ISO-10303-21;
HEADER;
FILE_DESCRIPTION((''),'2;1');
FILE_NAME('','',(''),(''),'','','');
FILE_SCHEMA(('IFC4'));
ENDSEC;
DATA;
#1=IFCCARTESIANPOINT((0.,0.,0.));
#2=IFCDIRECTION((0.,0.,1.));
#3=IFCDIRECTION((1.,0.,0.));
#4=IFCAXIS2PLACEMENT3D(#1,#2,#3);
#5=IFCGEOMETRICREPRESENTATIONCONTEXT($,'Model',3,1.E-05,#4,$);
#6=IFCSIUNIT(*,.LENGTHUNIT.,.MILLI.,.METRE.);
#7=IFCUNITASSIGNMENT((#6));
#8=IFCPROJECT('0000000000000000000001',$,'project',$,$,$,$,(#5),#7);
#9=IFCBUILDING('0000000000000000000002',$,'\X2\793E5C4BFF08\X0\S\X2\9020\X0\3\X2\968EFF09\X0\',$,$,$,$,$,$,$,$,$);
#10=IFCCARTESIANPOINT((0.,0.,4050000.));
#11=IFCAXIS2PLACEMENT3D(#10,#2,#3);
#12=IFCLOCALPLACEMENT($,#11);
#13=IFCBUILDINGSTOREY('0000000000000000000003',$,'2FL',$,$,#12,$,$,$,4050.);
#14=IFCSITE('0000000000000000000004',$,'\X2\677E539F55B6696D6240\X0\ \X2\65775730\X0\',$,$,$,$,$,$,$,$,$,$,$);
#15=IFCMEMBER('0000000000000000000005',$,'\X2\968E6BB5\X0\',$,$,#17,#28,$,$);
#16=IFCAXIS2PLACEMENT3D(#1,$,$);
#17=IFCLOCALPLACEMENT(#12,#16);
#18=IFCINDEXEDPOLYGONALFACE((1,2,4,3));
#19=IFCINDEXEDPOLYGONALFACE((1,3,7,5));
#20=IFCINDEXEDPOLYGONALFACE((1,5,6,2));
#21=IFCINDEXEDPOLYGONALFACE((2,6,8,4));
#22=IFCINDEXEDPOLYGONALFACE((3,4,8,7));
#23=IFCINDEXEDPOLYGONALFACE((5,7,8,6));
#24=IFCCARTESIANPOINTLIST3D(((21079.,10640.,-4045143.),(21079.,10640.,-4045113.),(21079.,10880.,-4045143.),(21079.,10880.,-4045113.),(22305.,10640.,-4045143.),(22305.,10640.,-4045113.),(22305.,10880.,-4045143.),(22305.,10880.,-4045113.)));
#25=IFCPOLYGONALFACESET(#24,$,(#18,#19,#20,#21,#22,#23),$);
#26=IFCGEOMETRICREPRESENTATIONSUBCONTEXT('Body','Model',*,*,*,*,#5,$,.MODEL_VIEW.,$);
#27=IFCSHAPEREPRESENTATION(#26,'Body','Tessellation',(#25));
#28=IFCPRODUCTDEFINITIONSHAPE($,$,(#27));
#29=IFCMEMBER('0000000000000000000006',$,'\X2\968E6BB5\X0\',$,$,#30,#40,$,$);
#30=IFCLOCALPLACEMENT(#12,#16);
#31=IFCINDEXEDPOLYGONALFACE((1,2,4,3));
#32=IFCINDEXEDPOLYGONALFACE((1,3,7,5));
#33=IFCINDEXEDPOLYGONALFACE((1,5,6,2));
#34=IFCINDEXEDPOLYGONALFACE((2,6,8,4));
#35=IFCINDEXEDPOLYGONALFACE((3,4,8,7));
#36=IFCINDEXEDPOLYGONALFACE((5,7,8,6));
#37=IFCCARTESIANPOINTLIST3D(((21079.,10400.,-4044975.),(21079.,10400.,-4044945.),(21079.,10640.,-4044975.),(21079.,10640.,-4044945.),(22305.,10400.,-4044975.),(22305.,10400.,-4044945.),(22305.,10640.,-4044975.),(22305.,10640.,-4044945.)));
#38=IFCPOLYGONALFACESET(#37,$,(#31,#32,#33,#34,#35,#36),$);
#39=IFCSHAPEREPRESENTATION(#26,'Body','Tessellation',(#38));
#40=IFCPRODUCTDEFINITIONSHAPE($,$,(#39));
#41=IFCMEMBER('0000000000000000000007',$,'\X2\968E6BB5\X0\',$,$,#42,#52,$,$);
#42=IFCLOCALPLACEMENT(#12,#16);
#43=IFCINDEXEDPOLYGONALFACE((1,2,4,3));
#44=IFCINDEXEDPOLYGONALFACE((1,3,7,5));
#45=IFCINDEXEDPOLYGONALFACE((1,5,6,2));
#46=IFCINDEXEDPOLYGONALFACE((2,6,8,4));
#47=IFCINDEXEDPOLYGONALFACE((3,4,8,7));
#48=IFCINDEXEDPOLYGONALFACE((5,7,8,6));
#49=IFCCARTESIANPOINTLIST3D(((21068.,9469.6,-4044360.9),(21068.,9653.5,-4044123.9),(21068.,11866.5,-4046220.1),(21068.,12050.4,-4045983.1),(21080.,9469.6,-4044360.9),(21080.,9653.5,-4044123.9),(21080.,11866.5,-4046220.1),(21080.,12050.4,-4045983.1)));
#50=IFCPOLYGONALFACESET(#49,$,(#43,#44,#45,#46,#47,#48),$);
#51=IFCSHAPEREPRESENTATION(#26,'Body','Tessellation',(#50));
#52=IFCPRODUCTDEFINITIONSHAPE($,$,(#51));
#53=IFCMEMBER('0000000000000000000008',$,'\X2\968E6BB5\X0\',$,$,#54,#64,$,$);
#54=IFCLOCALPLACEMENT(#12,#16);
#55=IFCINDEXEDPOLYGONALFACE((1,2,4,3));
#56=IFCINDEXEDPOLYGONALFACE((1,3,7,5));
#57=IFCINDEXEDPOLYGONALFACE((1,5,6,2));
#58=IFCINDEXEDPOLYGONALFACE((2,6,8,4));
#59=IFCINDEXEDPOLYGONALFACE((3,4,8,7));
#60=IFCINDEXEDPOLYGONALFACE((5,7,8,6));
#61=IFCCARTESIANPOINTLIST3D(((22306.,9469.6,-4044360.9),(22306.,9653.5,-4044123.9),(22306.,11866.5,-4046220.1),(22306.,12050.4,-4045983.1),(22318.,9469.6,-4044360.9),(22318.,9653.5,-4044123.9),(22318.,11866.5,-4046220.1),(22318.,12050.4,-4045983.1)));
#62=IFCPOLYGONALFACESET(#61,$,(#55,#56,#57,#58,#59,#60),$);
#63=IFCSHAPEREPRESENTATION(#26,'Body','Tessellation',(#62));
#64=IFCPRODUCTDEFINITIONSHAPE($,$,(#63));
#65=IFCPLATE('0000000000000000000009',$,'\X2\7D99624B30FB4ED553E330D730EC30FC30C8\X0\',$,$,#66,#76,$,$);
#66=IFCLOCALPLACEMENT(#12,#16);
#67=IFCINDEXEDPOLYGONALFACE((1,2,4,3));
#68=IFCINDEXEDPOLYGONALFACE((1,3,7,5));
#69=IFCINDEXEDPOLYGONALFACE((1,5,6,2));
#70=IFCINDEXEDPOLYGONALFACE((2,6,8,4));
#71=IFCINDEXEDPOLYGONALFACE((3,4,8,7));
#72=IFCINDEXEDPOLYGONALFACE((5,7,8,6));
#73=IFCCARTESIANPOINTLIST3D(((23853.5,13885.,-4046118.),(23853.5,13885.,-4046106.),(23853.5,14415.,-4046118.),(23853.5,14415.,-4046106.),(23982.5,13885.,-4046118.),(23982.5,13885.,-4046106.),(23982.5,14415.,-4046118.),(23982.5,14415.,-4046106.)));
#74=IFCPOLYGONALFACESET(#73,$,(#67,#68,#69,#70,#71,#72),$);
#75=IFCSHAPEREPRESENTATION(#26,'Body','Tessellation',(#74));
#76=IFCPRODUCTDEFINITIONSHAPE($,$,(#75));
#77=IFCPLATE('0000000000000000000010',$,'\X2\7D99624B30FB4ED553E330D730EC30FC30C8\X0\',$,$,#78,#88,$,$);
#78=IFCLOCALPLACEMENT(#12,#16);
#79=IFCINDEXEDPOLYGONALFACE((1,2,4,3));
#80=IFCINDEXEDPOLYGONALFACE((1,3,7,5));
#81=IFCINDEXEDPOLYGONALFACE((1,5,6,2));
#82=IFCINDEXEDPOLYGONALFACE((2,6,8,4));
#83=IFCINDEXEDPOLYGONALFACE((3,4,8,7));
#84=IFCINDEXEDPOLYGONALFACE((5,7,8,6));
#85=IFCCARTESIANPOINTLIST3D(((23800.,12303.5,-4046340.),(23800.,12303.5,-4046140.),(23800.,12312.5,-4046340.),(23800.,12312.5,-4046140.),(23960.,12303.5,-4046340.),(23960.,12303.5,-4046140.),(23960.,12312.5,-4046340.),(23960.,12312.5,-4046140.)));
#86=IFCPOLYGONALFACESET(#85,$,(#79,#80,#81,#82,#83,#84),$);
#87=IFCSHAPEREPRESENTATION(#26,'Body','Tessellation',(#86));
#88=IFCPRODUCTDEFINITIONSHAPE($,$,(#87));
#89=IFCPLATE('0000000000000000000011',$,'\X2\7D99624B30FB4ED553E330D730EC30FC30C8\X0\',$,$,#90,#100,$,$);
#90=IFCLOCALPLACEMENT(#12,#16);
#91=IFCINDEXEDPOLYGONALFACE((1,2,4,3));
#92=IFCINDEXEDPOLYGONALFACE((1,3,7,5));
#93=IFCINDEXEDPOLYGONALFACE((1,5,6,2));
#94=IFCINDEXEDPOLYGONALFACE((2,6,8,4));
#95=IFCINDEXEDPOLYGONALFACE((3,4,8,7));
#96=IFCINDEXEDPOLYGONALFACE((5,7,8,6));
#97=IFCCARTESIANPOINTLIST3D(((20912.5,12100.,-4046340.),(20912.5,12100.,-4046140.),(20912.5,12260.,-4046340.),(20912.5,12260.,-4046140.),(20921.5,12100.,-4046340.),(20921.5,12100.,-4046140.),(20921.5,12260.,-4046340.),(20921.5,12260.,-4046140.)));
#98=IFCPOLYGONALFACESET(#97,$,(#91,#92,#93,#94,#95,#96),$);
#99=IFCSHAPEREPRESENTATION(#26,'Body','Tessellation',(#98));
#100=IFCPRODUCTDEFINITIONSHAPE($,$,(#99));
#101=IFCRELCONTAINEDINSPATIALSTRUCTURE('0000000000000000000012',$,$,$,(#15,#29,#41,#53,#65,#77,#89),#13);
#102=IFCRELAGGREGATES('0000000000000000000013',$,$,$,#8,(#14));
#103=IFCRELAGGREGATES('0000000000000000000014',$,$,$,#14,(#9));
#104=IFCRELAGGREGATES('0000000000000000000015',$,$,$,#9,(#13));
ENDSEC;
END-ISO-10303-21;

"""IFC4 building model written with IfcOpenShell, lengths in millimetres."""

from ifc_helpers import new_model, si_unit, frame, origin, origin_with_axes, place, context, subcontext, project, spatial, rectangle, extrude, element, save


model = new_model("IFC4")

# Units and contexts
model_context = context("Model", 3, precision=1e-05, world=origin_with_axes())
body_context = subcontext(model_context, "Body", "Model", "MODEL_VIEW")
ifc_project = project(units=[si_unit("LENGTHUNIT", "METRE", prefix="MILLI")], contexts=[model_context])

# Site, building, storey
site = spatial("IfcSite", under=ifc_project, Name="松原営業所 敷地")
building = spatial("IfcBuilding", under=site, Name="社屋（S造3階）")
storey_placement = place(None, frame((0.0, 0.0, 4050000.0), z_axis=(0.0, 0.0, 1.0), x_axis=(1.0, 0.0, 0.0)))
storey = spatial("IfcBuildingStorey", under=building, at=storey_placement, Name="2FL", Elevation=4050.0)

# Members
for number, where, z_axis, x_axis, name in (
    (1, (21692.0, 10640.0, -4045128.0), (0.0, 1.0, 0.0), (-1.0, 0.0, 0.0), "階段"),
    (2, (21692.0, 10400.0, -4044960.0), (0.0, 1.0, 0.0), (-1.0, 0.0, 0.0), "階段"),
):
    element("IfcMember", number, at=place(storey_placement, frame(where, z_axis=z_axis, x_axis=x_axis)), inside=storey, Name=name, context=body_context, shape_type="SweptSolid", body=[
        extrude(rectangle(XDim=1226.0, YDim=30.0), origin(), (0.0, 0.0, 1.0), 240.0),
    ])
for number, where, z_axis, x_axis, name in (
    (3, (21074.0, 11958.4, -4046101.6), (0.0, -0.790155, 0.612907), (1.0, 0.0, 0.0), "階段"),
    (4, (22312.0, 11958.4, -4046101.6), (0.0, -0.790155, 0.612907), (1.0, 0.0, 0.0), "階段"),
):
    element("IfcMember", number, at=place(storey_placement, frame(where, z_axis=z_axis, x_axis=x_axis)), inside=storey, Name=name, context=body_context, shape_type="SweptSolid", body=[
        extrude(rectangle(XDim=12.0, YDim=300.0), origin(), (0.0, 0.0, 1.0), 3033.4),
    ])

# Plates
plate_placement = place(storey_placement, frame((23918.0, 13885.0, -4046112.0), z_axis=(0.0, 1.0, 0.0), x_axis=(-1.0, 0.0, 0.0)))
element("IfcPlate", 5, at=plate_placement, inside=storey, Name="継手・仕口プレート", context=body_context, shape_type="SweptSolid", body=[
    extrude(rectangle(XDim=129.0, YDim=12.0), origin(), (0.0, 0.0, 1.0), 530.0),
])
for number, where, z_axis, x_axis, name in (
    (6, (23800.0, 12308.0, -4046240.0), (1.0, 0.0, 0.0), (0.0, 1.0, 0.0), "継手・仕口プレート"),
    (7, (20917.0, 12100.0, -4046240.0), (0.0, 1.0, 0.0), (-1.0, 0.0, 0.0), "継手・仕口プレート"),
):
    element("IfcPlate", number, at=place(storey_placement, frame(where, z_axis=z_axis, x_axis=x_axis)), inside=storey, Name=name, context=body_context, shape_type="SweptSolid", body=[
        extrude(rectangle(XDim=9.0, YDim=200.0), origin(), (0.0, 0.0, 1.0), 160.0),
    ])

save(model, "model.ifc")
